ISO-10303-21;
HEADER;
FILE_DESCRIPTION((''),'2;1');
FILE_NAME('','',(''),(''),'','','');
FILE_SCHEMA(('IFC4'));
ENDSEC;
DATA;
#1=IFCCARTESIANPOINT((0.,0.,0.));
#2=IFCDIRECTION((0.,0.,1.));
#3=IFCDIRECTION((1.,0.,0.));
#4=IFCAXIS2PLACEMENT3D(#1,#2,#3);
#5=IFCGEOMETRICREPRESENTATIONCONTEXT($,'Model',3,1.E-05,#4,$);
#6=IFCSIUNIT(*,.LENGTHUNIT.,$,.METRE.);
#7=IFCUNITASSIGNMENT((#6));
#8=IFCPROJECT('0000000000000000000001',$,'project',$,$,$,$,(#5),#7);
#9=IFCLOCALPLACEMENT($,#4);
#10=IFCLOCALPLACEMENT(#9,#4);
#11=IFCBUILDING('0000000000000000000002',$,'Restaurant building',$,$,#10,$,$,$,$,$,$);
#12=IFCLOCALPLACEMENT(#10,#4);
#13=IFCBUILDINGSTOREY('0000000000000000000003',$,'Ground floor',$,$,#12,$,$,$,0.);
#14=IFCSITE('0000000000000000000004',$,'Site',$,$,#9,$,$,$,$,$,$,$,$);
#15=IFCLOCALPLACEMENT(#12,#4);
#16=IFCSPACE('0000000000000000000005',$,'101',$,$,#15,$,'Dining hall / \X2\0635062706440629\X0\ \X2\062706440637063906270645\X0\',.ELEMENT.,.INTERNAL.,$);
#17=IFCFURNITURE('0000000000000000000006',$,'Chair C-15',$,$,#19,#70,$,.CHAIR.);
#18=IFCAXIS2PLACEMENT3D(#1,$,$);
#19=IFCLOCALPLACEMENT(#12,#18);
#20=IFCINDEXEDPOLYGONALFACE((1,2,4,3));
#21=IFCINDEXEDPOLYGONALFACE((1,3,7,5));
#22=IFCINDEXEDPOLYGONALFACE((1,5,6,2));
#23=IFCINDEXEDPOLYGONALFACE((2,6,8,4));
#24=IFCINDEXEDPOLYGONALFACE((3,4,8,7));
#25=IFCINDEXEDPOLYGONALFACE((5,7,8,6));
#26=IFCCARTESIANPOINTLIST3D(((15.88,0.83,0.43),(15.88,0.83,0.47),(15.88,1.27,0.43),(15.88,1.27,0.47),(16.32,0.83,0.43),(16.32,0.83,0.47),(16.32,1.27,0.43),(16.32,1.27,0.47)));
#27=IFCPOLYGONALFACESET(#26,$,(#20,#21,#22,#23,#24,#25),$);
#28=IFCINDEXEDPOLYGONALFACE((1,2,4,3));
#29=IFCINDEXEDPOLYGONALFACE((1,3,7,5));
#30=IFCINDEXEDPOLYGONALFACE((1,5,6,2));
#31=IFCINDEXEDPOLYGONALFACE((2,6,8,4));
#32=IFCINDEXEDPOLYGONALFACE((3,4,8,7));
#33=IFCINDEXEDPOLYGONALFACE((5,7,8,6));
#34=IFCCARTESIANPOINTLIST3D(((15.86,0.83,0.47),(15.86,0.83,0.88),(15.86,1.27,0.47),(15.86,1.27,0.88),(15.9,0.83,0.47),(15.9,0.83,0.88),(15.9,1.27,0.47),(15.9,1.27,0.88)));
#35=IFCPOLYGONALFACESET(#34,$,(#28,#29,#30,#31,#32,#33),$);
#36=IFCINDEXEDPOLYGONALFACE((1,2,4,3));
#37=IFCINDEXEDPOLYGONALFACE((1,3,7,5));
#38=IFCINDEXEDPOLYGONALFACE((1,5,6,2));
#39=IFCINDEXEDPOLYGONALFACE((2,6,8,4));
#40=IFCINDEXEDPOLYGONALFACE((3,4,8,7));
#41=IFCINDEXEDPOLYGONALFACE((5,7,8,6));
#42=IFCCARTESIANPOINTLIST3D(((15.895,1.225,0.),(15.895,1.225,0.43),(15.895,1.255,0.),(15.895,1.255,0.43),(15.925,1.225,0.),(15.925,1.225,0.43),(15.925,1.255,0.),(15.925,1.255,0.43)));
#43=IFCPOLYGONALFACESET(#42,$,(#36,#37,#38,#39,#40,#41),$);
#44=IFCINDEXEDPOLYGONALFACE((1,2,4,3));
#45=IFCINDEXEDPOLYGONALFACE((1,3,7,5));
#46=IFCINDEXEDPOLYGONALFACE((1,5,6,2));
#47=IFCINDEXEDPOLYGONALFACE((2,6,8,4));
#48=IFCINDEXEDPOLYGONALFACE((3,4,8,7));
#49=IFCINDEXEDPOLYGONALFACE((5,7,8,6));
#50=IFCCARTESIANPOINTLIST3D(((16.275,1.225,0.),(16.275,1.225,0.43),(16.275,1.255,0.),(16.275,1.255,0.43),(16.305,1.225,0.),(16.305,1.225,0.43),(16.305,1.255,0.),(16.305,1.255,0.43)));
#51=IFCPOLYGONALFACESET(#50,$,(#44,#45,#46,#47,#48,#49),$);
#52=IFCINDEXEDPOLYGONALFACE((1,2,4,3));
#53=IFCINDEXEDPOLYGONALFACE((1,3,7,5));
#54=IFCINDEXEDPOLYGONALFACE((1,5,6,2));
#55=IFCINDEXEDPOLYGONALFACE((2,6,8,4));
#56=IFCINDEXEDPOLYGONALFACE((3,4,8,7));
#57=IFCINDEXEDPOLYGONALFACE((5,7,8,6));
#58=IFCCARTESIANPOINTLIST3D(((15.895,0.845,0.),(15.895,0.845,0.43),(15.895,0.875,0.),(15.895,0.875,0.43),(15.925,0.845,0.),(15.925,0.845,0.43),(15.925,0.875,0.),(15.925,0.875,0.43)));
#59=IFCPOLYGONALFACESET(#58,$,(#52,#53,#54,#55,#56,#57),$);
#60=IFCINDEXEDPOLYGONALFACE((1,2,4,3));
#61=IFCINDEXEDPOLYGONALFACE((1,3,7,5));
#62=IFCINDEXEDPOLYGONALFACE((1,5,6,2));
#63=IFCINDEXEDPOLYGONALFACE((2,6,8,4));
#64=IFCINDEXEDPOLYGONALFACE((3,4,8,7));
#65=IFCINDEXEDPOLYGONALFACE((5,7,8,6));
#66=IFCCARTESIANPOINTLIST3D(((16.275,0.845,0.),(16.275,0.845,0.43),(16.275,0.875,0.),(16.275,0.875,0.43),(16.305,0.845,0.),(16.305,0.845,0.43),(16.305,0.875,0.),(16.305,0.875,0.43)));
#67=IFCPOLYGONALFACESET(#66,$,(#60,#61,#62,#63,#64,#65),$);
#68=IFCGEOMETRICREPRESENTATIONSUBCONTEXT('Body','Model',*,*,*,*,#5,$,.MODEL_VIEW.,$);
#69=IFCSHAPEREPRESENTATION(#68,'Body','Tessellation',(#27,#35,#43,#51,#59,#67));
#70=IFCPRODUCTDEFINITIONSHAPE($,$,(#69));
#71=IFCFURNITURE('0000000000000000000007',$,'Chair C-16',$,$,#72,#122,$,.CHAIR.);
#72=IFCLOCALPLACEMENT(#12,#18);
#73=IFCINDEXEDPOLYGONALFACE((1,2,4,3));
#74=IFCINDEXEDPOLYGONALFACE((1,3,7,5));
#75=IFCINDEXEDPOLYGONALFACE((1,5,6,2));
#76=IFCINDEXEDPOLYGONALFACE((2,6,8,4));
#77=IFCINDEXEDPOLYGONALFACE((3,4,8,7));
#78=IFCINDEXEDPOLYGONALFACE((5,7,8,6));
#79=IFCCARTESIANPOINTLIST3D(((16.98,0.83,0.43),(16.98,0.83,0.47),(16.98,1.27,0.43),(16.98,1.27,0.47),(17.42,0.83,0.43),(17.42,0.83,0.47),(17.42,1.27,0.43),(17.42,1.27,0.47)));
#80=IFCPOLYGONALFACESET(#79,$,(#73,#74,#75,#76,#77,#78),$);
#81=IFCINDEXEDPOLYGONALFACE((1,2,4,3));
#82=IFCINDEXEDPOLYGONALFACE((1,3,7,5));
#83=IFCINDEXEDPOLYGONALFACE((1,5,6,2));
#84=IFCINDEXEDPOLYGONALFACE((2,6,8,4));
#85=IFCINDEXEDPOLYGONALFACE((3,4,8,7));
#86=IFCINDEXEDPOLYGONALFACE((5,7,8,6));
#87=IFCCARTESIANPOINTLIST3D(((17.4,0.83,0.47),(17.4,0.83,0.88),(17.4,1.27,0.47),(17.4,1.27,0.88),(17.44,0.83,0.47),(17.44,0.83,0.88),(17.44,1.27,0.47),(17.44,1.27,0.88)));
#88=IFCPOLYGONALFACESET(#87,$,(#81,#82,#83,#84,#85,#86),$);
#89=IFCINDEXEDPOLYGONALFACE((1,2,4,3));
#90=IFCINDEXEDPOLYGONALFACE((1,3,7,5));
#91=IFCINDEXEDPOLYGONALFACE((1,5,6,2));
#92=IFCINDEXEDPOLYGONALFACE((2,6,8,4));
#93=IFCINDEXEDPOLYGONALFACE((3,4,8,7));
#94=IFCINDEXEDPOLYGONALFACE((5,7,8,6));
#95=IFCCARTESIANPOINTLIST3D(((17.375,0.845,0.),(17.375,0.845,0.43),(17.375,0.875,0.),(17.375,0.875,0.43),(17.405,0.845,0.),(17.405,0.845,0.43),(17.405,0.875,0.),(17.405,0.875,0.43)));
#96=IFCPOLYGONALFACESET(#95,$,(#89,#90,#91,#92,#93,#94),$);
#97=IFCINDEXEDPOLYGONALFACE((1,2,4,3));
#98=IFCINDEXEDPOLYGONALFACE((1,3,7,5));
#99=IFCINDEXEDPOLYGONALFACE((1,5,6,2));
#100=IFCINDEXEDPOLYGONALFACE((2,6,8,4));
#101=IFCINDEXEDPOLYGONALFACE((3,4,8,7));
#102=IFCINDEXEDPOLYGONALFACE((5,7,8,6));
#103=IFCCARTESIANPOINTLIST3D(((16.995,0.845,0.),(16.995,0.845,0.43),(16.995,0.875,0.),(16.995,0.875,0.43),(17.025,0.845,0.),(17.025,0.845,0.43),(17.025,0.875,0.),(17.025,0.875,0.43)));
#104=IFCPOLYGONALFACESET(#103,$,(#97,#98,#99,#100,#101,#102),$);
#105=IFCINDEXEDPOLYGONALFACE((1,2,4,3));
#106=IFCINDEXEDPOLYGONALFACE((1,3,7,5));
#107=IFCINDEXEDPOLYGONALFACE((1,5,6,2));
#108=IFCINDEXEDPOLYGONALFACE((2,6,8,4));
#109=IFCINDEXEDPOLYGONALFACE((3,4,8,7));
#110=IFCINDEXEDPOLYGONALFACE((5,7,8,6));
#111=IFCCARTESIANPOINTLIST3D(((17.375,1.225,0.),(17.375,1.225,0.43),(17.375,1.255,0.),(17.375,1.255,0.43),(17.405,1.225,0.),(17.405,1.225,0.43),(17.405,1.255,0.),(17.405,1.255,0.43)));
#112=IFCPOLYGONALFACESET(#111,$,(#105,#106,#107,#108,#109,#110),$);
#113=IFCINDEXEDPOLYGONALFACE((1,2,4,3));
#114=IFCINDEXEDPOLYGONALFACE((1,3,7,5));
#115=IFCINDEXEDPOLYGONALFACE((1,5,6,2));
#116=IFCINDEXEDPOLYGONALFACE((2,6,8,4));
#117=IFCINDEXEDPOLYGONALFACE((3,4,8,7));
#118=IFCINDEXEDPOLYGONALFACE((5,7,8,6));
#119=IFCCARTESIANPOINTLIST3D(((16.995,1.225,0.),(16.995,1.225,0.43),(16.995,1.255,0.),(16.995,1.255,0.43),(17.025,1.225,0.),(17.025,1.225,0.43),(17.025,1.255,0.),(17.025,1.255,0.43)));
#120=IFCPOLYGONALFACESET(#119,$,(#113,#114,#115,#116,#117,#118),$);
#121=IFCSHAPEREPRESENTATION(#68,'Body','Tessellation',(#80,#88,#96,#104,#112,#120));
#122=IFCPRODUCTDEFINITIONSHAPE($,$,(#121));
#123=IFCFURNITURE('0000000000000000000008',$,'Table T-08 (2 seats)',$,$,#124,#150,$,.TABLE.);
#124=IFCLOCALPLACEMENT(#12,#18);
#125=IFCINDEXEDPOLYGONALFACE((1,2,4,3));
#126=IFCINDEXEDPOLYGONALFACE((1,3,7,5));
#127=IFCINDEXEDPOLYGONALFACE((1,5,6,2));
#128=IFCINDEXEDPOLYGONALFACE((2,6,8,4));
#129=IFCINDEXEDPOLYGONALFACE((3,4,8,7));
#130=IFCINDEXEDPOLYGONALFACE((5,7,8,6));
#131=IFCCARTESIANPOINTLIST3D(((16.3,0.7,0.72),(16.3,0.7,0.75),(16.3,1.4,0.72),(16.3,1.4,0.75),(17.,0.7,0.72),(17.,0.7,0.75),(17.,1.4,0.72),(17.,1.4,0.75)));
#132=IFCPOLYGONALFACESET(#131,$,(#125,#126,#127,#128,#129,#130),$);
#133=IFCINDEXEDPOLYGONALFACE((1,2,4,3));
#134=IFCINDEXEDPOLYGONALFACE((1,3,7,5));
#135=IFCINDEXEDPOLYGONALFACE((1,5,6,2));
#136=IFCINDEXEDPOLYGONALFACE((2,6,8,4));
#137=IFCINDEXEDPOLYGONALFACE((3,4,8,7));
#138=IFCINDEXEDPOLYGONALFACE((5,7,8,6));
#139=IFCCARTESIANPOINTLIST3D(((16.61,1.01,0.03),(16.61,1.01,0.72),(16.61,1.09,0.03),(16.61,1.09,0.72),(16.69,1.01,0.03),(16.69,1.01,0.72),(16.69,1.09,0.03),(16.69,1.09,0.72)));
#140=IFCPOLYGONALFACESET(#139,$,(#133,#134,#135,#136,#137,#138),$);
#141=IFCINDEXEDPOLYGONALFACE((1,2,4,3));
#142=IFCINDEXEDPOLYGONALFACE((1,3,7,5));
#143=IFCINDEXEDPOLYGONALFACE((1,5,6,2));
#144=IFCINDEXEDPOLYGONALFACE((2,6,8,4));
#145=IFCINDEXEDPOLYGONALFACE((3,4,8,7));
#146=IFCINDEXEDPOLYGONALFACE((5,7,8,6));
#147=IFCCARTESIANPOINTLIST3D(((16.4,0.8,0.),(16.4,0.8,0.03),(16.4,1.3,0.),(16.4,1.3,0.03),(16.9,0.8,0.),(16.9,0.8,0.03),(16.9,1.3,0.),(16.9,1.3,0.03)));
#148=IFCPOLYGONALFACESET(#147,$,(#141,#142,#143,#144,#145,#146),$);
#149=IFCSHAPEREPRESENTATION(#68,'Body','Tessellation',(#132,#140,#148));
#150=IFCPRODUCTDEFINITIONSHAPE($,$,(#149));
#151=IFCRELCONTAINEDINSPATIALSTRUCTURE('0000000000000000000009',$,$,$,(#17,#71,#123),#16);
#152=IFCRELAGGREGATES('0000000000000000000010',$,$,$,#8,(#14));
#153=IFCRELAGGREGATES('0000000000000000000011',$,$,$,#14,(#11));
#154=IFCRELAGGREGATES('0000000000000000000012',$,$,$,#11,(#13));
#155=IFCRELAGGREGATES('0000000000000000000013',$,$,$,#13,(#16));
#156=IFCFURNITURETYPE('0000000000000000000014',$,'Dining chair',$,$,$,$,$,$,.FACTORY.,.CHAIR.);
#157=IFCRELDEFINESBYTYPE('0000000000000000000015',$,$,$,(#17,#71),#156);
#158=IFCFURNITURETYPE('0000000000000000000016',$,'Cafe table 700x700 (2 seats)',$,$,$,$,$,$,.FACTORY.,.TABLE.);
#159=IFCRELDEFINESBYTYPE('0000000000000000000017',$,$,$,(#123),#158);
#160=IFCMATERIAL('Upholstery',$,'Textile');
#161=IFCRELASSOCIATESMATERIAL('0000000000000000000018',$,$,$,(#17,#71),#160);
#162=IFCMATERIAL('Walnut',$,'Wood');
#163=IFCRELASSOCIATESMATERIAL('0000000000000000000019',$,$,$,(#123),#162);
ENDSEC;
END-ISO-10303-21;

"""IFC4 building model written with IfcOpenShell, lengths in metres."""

from ifc_helpers import new_model, si_unit, frame, origin, origin_with_axes, origin_2d, place, context, subcontext, project, spatial, rectangle, extrude, source, transform, mapped, material, type_object, type_shapes, element, save


model = new_model("IFC4")

# Units and contexts
model_context = context("Model", 3, precision=1e-05, world=origin_with_axes())
body_context = subcontext(model_context, "Body", "Model", "MODEL_VIEW")
ifc_project = project(units=[si_unit("LENGTHUNIT", "METRE")], contexts=[model_context])

# Site, building, storey
site_placement = place(None, origin_with_axes())
site = spatial("IfcSite", under=ifc_project, at=site_placement, Name="Site")
building_placement = place(site_placement, origin_with_axes())
building = spatial("IfcBuilding", under=site, at=building_placement, Name="Restaurant building")
storey_placement = place(building_placement, origin_with_axes())
storey = spatial("IfcBuildingStorey", under=building, at=storey_placement, Name="Ground floor", Elevation=0.0)

# Shared definitions
space_placement = place(storey_placement, origin_with_axes())
space = spatial("IfcSpace", under=storey, at=space_placement, Name="101", LongName="Dining hall / صالة الطعام", CompositionType="ELEMENT", PredefinedType="INTERNAL")

# Furniture
ifc_material_1 = material(Name="Upholstery", Category="Textile")
furniture_type_1 = type_object("IfcFurnitureType", Name="Dining chair", AssemblyPlace="FACTORY", PredefinedType="CHAIR")
shared_shape_1 = source(origin(), body_context, "Body", "SweptSolid", [
    extrude(rectangle(XDim=0.44, YDim=0.44, at=origin_2d()), frame((0.0, 0.0, 0.43)), (0.0, 0.0, 1.0), 0.04),
    extrude(rectangle(XDim=0.44, YDim=0.04, at=origin_2d()), frame((0.0, -0.22, 0.47)), (0.0, 0.0, 1.0), 0.41),
    extrude(rectangle(XDim=0.03, YDim=0.03, at=origin_2d()), frame((-0.19, -0.19, 0.0)), (0.0, 0.0, 1.0), 0.43),
    extrude(rectangle(XDim=0.03, YDim=0.03, at=origin_2d()), frame((-0.19, 0.19, 0.0)), (0.0, 0.0, 1.0), 0.43),
    extrude(rectangle(XDim=0.03, YDim=0.03, at=origin_2d()), frame((0.19, -0.19, 0.0)), (0.0, 0.0, 1.0), 0.43),
    extrude(rectangle(XDim=0.03, YDim=0.03, at=origin_2d()), frame((0.19, 0.19, 0.0)), (0.0, 0.0, 1.0), 0.43),
])
type_shapes(furniture_type_1, [shared_shape_1])
for number, where, z_axis, x_axis, name in (
    (1, (16.1, 1.05, 0.0), (0.0, 0.0, 1.0), (0.0, -1.0, 0.0), "Chair C-15"),
    (2, (17.2, 1.05, 0.0), (0.0, 0.0, 1.0), (0.0, 1.0, 0.0), "Chair C-16"),
):
    element("IfcFurniture", number, at=place(storey_placement, frame(where, z_axis=z_axis, x_axis=x_axis)), inside=space, type_object=furniture_type_1, material=ifc_material_1, Name=name, PredefinedType="CHAIR", context=body_context, shape_type="MappedRepresentation", body=[
        mapped(shared_shape_1, transform((0.0, 0.0, 0.0))),
    ])
ifc_material_2 = material(Name="Walnut", Category="Wood")
furniture_type_2 = type_object("IfcFurnitureType", Name="Cafe table 700x700 (2 seats)", AssemblyPlace="FACTORY", PredefinedType="TABLE")
shared_shape_2 = source(origin(), body_context, "Body", "SweptSolid", [
    extrude(rectangle(XDim=0.7, YDim=0.7, at=origin_2d()), frame((0.0, 0.0, 0.72)), (0.0, 0.0, 1.0), 0.03),
    extrude(rectangle(XDim=0.08, YDim=0.08, at=origin_2d()), frame((0.0, 0.0, 0.03)), (0.0, 0.0, 1.0), 0.69),
    extrude(rectangle(XDim=0.5, YDim=0.5, at=origin_2d()), origin(), (0.0, 0.0, 1.0), 0.03),
])
type_shapes(furniture_type_2, [shared_shape_2])
furniture_placement = place(storey_placement, frame((16.65, 1.05, 0.0)))
element("IfcFurniture", 3, at=furniture_placement, inside=space, type_object=furniture_type_2, material=ifc_material_2, Name="Table T-08 (2 seats)", PredefinedType="TABLE", context=body_context, shape_type="MappedRepresentation", body=[
    mapped(shared_shape_2, transform((0.0, 0.0, 0.0))),
])

save(model, "model.ifc")
